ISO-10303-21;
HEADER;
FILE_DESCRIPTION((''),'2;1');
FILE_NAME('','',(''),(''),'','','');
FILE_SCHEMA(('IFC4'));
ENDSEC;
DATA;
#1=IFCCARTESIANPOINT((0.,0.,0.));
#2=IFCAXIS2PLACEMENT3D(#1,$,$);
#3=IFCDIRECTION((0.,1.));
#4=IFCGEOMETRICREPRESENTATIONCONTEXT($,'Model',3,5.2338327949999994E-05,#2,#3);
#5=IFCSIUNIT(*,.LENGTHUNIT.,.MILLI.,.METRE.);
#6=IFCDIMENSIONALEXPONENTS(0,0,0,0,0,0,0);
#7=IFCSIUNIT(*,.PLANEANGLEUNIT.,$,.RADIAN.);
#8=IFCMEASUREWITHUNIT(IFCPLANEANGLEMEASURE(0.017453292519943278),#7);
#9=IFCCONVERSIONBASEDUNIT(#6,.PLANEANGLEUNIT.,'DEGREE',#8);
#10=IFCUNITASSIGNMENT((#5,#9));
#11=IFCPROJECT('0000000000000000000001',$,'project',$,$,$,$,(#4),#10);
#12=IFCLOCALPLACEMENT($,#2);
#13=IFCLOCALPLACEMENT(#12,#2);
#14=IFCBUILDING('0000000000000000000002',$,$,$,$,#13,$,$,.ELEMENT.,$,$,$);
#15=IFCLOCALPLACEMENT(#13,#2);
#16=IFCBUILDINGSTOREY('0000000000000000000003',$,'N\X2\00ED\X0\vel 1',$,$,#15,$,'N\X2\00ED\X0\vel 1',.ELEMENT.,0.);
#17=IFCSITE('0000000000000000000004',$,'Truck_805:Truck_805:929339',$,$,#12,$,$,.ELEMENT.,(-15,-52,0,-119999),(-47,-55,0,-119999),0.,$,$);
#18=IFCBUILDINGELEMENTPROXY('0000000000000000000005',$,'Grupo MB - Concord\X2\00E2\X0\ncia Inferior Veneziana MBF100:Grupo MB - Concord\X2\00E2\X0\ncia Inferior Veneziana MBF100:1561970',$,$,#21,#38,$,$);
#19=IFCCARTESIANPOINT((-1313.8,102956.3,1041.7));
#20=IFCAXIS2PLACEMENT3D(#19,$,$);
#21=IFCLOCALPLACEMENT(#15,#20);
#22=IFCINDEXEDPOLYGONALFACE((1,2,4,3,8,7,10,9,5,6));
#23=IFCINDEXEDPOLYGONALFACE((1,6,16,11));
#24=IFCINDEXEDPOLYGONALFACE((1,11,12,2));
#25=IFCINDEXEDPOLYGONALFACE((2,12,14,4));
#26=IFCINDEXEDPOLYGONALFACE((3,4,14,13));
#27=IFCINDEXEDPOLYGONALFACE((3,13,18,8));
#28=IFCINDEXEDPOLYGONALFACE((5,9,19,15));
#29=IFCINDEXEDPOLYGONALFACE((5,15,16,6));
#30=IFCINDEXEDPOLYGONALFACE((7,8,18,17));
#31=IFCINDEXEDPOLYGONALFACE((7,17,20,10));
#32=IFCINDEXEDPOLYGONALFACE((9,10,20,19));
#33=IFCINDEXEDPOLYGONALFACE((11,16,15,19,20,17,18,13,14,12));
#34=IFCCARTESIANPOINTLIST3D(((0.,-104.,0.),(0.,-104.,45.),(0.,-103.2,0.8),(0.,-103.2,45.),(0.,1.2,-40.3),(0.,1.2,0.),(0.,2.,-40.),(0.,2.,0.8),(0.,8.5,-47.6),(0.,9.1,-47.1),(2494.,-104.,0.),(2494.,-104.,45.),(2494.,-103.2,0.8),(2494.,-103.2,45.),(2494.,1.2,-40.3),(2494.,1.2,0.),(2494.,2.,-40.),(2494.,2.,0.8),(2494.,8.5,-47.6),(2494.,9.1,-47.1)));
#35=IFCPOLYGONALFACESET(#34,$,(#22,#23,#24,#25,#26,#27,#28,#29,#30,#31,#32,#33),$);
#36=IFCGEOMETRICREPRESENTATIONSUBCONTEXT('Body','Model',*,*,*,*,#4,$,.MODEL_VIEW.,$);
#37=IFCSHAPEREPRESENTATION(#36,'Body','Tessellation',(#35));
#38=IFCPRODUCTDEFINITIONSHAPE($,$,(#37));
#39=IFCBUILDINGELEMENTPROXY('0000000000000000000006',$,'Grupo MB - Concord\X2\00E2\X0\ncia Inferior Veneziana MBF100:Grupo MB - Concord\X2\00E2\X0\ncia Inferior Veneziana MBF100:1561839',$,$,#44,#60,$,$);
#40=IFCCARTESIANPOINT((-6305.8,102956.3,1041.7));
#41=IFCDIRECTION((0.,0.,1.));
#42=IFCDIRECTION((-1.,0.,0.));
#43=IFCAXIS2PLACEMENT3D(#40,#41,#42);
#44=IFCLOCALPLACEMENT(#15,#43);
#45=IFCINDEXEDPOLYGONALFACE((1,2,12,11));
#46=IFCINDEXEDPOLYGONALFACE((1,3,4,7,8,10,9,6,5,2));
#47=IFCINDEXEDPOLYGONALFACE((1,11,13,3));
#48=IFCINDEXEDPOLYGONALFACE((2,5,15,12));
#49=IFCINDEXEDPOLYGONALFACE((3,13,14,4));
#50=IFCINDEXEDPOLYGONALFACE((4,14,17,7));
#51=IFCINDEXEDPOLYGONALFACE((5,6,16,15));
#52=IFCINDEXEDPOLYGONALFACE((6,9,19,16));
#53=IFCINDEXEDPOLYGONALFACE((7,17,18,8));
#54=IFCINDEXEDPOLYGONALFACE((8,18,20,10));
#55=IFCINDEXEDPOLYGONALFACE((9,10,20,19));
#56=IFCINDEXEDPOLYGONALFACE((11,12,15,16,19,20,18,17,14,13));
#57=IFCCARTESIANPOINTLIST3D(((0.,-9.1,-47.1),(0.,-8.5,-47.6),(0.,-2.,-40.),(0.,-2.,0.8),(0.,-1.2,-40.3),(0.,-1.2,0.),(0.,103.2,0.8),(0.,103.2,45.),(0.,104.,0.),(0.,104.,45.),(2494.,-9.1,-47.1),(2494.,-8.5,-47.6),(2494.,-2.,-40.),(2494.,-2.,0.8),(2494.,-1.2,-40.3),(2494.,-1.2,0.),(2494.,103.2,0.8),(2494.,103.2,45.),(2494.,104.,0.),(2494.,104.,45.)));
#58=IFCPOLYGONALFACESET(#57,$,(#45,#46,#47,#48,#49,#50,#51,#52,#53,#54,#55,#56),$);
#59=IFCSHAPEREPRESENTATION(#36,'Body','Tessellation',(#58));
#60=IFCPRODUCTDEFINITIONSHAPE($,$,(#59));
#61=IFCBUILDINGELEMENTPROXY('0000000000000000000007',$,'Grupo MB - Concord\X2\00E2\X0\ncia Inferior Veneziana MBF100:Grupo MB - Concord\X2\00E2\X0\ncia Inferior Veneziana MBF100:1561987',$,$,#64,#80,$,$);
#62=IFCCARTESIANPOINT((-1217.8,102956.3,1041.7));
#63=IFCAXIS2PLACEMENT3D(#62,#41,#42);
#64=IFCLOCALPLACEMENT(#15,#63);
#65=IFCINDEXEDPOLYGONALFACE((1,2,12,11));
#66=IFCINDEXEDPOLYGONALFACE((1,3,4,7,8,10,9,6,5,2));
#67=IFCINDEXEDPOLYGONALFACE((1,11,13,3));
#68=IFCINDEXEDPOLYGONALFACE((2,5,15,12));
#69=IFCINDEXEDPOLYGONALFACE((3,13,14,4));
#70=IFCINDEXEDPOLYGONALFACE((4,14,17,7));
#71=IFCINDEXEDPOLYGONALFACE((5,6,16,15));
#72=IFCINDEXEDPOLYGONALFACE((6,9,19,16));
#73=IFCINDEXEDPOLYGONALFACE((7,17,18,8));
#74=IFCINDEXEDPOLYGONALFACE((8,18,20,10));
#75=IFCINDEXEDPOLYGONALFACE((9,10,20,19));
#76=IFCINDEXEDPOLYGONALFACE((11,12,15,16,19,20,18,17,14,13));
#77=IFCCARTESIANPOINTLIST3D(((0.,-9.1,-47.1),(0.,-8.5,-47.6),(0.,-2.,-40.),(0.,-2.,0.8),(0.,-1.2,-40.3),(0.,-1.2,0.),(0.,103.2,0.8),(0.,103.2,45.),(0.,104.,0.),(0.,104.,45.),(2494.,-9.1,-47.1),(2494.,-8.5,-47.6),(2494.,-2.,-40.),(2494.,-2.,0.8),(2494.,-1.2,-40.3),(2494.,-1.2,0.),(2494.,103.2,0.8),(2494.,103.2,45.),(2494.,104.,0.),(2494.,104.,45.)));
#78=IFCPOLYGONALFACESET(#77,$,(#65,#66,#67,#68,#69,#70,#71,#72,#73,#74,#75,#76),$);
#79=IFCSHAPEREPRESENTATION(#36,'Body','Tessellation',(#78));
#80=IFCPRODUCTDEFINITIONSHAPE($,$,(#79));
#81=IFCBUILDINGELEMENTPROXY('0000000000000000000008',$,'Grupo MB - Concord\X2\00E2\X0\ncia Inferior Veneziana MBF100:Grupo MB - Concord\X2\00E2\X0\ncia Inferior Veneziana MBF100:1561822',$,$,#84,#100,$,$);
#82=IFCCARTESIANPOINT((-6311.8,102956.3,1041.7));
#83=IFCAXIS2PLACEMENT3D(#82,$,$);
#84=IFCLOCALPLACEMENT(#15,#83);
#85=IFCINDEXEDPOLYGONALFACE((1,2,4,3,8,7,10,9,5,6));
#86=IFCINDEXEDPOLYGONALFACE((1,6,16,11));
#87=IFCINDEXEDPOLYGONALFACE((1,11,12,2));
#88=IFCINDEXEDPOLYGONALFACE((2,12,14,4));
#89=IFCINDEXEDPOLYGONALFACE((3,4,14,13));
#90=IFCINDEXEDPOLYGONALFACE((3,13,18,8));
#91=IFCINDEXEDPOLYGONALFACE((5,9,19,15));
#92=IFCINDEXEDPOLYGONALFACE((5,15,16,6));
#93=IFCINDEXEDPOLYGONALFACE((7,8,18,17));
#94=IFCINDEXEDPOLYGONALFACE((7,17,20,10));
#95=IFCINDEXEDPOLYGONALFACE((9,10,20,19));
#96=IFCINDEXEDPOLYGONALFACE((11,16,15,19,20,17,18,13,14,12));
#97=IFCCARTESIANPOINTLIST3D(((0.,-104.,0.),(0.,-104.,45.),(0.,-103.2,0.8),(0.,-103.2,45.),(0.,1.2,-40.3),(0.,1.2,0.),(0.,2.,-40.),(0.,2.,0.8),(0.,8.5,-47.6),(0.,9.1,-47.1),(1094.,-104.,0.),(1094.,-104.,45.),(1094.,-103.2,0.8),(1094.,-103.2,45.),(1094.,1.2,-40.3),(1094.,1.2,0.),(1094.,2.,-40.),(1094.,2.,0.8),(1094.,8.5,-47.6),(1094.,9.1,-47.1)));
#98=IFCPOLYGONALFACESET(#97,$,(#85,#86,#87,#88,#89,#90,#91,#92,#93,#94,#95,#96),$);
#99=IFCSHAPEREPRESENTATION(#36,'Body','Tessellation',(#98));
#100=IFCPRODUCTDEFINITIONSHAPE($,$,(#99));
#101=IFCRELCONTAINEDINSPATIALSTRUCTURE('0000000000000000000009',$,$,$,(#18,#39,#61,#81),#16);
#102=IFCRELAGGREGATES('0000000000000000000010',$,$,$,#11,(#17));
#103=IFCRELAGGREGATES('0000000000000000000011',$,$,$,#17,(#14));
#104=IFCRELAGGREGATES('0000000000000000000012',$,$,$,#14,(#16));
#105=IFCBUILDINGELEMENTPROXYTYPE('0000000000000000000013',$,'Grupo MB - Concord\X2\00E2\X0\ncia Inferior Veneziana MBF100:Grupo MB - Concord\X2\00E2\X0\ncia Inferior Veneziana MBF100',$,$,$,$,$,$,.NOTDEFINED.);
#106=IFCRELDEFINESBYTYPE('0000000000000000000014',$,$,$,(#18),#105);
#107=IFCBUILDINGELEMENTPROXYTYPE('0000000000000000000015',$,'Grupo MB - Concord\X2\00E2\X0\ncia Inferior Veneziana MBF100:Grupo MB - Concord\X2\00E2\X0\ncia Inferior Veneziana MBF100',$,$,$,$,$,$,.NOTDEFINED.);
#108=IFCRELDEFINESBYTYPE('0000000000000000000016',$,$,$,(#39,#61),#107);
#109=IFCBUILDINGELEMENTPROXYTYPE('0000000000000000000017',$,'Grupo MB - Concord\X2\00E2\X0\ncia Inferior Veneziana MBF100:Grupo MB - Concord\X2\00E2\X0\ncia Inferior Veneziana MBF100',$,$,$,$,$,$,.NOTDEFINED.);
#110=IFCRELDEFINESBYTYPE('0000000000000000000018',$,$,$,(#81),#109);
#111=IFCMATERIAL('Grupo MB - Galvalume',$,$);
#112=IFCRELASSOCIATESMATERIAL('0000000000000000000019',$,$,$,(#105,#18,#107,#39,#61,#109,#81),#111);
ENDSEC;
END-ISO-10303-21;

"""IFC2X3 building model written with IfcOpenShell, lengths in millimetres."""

from ifc_helpers import new_model, entity, si_unit, converted_unit, direction, frame, origin, place, context, subcontext, project, spatial, polyline, outline, extrude, source, transform, mapped, material, type_object, type_shapes, element, save


model = new_model("IFC2X3")

# Units and contexts
model_context = context("Model", 3, precision=5.2338327949999994e-05, world=origin(), true_north=direction((0.0, 1.0)))
body_context = subcontext(model_context, "Body", "Model", "MODEL_VIEW")
ifc_project = project(units=[si_unit("LENGTHUNIT", "METRE", prefix="MILLI"), converted_unit("PLANEANGLEUNIT", "DEGREE", entity("IfcPlaneAngleMeasure", 0.017453292519943278), si_unit("PLANEANGLEUNIT", "RADIAN"), dimensions=[0, 0, 0, 0, 0, 0, 0])], contexts=[model_context])

# Site, building, storey
site_placement = place(None, origin())
site = spatial("IfcSite", under=ifc_project, at=site_placement, Name="Truck_805:Truck_805:929339", CompositionType="ELEMENT", RefLatitude=(-15, -52, 0, -119999), RefLongitude=(-47, -55, 0, -119999), RefElevation=0.0)
building_placement = place(site_placement, origin())
building = spatial("IfcBuilding", under=site, at=building_placement, CompositionType="ELEMENT")
storey_placement = place(building_placement, origin())
storey = spatial("IfcBuildingStorey", under=building, at=storey_placement, Name="Nível 1", LongName="Nível 1", CompositionType="ELEMENT", Elevation=0.0)

# Building element proxies
ifc_material_1 = material(Name="Grupo MB - Galvalume")
building_element_proxy_type_1 = type_object("IfcBuildingElementProxyType", Name="Grupo MB - Concordância Inferior Veneziana MBF100:Grupo MB - Concordância Inferior Veneziana MBF100", PredefinedType="NOTDEFINED", material=ifc_material_1)
shared_shape_1 = source(origin(), body_context, "Body", "SweptSolid", [
    extrude(outline(polyline([(-8.3, 40.2), (32.0, 40.2), (39.3, 47.5), (38.7, 48.1), (31.7, 41.0), (-9.1, 41.0), (-9.1, -64.2), (-53.3, -64.2), (-53.3, -65.0), (-8.3, -65.0), (-8.3, 40.2)])), frame((0.0, -39.0, -8.3), z_axis=(1.0, 0.0, 0.0), x_axis=(0.0, 0.0, -1.0)), (0.0, 0.0, 1.0), 2494.0),
])
type_shapes(building_element_proxy_type_1, [shared_shape_1])
proxy_1_placement = place(storey_placement, frame((-1313.8, 102956.3, 1041.7)))
element("IfcBuildingElementProxy", 1, at=proxy_1_placement, inside=storey, type_object=building_element_proxy_type_1, material=ifc_material_1, Name="Grupo MB - Concordância Inferior Veneziana MBF100:Grupo MB - Concordância Inferior Veneziana MBF100:1561970", context=body_context, shape_type="MappedRepresentation", body=[
    mapped(shared_shape_1, transform((0.0, 0.0, 0.0), scale=1.0)),
])
building_element_proxy_type_2 = type_object("IfcBuildingElementProxyType", Name="Grupo MB - Concordância Inferior Veneziana MBF100:Grupo MB - Concordância Inferior Veneziana MBF100", PredefinedType="NOTDEFINED", material=ifc_material_1)
shared_shape_2 = source(origin(), body_context, "Body", "SweptSolid", [
    extrude(outline(polyline([(-40.2, 8.3), (65.0, 8.3), (65.0, 53.3), (64.2, 53.3), (64.2, 9.1), (-41.0, 9.1), (-41.0, -31.7), (-48.1, -38.7), (-47.5, -39.3), (-40.2, -32.0), (-40.2, 8.3)])), frame((0.0, 39.0, -8.3), z_axis=(1.0, 0.0, 0.0), x_axis=(0.0, 1.0, 0.0)), (0.0, 0.0, 1.0), 2494.0),
])
type_shapes(building_element_proxy_type_2, [shared_shape_2])
for number, where, z_axis, x_axis, name in (
    (2, (-6305.8, 102956.3, 1041.7), (0.0, 0.0, 1.0), (-1.0, 0.0, 0.0), "Grupo MB - Concordância Inferior Veneziana MBF100:Grupo MB - Concordância Inferior Veneziana MBF100:1561839"),
    (3, (-1217.8, 102956.3, 1041.7), (0.0, 0.0, 1.0), (-1.0, 0.0, 0.0), "Grupo MB - Concordância Inferior Veneziana MBF100:Grupo MB - Concordância Inferior Veneziana MBF100:1561987"),
):
    element("IfcBuildingElementProxy", number, at=place(storey_placement, frame(where, z_axis=z_axis, x_axis=x_axis)), inside=storey, type_object=building_element_proxy_type_2, material=ifc_material_1, Name=name, context=body_context, shape_type="MappedRepresentation", body=[
        mapped(shared_shape_2, transform((0.0, 0.0, 0.0), scale=1.0)),
    ])
building_element_proxy_type_3 = type_object("IfcBuildingElementProxyType", Name="Grupo MB - Concordância Inferior Veneziana MBF100:Grupo MB - Concordância Inferior Veneziana MBF100", PredefinedType="NOTDEFINED", material=ifc_material_1)
shared_shape_3 = source(origin(), body_context, "Body", "SweptSolid", [
    extrude(outline(polyline([(-8.3, 40.2), (32.0, 40.2), (39.3, 47.5), (38.7, 48.1), (31.7, 41.0), (-9.1, 41.0), (-9.1, -64.2), (-53.3, -64.2), (-53.3, -65.0), (-8.3, -65.0), (-8.3, 40.2)])), frame((0.0, -39.0, -8.3), z_axis=(1.0, 0.0, 0.0), x_axis=(0.0, 0.0, -1.0)), (0.0, 0.0, 1.0), 1094.0),
])
type_shapes(building_element_proxy_type_3, [shared_shape_3])
proxy_2_placement = place(storey_placement, frame((-6311.8, 102956.3, 1041.7)))
element("IfcBuildingElementProxy", 4, at=proxy_2_placement, inside=storey, type_object=building_element_proxy_type_3, material=ifc_material_1, Name="Grupo MB - Concordância Inferior Veneziana MBF100:Grupo MB - Concordância Inferior Veneziana MBF100:1561822", context=body_context, shape_type="MappedRepresentation", body=[
    mapped(shared_shape_3, transform((0.0, 0.0, 0.0), scale=1.0)),
])

save(model, "model.ifc")
